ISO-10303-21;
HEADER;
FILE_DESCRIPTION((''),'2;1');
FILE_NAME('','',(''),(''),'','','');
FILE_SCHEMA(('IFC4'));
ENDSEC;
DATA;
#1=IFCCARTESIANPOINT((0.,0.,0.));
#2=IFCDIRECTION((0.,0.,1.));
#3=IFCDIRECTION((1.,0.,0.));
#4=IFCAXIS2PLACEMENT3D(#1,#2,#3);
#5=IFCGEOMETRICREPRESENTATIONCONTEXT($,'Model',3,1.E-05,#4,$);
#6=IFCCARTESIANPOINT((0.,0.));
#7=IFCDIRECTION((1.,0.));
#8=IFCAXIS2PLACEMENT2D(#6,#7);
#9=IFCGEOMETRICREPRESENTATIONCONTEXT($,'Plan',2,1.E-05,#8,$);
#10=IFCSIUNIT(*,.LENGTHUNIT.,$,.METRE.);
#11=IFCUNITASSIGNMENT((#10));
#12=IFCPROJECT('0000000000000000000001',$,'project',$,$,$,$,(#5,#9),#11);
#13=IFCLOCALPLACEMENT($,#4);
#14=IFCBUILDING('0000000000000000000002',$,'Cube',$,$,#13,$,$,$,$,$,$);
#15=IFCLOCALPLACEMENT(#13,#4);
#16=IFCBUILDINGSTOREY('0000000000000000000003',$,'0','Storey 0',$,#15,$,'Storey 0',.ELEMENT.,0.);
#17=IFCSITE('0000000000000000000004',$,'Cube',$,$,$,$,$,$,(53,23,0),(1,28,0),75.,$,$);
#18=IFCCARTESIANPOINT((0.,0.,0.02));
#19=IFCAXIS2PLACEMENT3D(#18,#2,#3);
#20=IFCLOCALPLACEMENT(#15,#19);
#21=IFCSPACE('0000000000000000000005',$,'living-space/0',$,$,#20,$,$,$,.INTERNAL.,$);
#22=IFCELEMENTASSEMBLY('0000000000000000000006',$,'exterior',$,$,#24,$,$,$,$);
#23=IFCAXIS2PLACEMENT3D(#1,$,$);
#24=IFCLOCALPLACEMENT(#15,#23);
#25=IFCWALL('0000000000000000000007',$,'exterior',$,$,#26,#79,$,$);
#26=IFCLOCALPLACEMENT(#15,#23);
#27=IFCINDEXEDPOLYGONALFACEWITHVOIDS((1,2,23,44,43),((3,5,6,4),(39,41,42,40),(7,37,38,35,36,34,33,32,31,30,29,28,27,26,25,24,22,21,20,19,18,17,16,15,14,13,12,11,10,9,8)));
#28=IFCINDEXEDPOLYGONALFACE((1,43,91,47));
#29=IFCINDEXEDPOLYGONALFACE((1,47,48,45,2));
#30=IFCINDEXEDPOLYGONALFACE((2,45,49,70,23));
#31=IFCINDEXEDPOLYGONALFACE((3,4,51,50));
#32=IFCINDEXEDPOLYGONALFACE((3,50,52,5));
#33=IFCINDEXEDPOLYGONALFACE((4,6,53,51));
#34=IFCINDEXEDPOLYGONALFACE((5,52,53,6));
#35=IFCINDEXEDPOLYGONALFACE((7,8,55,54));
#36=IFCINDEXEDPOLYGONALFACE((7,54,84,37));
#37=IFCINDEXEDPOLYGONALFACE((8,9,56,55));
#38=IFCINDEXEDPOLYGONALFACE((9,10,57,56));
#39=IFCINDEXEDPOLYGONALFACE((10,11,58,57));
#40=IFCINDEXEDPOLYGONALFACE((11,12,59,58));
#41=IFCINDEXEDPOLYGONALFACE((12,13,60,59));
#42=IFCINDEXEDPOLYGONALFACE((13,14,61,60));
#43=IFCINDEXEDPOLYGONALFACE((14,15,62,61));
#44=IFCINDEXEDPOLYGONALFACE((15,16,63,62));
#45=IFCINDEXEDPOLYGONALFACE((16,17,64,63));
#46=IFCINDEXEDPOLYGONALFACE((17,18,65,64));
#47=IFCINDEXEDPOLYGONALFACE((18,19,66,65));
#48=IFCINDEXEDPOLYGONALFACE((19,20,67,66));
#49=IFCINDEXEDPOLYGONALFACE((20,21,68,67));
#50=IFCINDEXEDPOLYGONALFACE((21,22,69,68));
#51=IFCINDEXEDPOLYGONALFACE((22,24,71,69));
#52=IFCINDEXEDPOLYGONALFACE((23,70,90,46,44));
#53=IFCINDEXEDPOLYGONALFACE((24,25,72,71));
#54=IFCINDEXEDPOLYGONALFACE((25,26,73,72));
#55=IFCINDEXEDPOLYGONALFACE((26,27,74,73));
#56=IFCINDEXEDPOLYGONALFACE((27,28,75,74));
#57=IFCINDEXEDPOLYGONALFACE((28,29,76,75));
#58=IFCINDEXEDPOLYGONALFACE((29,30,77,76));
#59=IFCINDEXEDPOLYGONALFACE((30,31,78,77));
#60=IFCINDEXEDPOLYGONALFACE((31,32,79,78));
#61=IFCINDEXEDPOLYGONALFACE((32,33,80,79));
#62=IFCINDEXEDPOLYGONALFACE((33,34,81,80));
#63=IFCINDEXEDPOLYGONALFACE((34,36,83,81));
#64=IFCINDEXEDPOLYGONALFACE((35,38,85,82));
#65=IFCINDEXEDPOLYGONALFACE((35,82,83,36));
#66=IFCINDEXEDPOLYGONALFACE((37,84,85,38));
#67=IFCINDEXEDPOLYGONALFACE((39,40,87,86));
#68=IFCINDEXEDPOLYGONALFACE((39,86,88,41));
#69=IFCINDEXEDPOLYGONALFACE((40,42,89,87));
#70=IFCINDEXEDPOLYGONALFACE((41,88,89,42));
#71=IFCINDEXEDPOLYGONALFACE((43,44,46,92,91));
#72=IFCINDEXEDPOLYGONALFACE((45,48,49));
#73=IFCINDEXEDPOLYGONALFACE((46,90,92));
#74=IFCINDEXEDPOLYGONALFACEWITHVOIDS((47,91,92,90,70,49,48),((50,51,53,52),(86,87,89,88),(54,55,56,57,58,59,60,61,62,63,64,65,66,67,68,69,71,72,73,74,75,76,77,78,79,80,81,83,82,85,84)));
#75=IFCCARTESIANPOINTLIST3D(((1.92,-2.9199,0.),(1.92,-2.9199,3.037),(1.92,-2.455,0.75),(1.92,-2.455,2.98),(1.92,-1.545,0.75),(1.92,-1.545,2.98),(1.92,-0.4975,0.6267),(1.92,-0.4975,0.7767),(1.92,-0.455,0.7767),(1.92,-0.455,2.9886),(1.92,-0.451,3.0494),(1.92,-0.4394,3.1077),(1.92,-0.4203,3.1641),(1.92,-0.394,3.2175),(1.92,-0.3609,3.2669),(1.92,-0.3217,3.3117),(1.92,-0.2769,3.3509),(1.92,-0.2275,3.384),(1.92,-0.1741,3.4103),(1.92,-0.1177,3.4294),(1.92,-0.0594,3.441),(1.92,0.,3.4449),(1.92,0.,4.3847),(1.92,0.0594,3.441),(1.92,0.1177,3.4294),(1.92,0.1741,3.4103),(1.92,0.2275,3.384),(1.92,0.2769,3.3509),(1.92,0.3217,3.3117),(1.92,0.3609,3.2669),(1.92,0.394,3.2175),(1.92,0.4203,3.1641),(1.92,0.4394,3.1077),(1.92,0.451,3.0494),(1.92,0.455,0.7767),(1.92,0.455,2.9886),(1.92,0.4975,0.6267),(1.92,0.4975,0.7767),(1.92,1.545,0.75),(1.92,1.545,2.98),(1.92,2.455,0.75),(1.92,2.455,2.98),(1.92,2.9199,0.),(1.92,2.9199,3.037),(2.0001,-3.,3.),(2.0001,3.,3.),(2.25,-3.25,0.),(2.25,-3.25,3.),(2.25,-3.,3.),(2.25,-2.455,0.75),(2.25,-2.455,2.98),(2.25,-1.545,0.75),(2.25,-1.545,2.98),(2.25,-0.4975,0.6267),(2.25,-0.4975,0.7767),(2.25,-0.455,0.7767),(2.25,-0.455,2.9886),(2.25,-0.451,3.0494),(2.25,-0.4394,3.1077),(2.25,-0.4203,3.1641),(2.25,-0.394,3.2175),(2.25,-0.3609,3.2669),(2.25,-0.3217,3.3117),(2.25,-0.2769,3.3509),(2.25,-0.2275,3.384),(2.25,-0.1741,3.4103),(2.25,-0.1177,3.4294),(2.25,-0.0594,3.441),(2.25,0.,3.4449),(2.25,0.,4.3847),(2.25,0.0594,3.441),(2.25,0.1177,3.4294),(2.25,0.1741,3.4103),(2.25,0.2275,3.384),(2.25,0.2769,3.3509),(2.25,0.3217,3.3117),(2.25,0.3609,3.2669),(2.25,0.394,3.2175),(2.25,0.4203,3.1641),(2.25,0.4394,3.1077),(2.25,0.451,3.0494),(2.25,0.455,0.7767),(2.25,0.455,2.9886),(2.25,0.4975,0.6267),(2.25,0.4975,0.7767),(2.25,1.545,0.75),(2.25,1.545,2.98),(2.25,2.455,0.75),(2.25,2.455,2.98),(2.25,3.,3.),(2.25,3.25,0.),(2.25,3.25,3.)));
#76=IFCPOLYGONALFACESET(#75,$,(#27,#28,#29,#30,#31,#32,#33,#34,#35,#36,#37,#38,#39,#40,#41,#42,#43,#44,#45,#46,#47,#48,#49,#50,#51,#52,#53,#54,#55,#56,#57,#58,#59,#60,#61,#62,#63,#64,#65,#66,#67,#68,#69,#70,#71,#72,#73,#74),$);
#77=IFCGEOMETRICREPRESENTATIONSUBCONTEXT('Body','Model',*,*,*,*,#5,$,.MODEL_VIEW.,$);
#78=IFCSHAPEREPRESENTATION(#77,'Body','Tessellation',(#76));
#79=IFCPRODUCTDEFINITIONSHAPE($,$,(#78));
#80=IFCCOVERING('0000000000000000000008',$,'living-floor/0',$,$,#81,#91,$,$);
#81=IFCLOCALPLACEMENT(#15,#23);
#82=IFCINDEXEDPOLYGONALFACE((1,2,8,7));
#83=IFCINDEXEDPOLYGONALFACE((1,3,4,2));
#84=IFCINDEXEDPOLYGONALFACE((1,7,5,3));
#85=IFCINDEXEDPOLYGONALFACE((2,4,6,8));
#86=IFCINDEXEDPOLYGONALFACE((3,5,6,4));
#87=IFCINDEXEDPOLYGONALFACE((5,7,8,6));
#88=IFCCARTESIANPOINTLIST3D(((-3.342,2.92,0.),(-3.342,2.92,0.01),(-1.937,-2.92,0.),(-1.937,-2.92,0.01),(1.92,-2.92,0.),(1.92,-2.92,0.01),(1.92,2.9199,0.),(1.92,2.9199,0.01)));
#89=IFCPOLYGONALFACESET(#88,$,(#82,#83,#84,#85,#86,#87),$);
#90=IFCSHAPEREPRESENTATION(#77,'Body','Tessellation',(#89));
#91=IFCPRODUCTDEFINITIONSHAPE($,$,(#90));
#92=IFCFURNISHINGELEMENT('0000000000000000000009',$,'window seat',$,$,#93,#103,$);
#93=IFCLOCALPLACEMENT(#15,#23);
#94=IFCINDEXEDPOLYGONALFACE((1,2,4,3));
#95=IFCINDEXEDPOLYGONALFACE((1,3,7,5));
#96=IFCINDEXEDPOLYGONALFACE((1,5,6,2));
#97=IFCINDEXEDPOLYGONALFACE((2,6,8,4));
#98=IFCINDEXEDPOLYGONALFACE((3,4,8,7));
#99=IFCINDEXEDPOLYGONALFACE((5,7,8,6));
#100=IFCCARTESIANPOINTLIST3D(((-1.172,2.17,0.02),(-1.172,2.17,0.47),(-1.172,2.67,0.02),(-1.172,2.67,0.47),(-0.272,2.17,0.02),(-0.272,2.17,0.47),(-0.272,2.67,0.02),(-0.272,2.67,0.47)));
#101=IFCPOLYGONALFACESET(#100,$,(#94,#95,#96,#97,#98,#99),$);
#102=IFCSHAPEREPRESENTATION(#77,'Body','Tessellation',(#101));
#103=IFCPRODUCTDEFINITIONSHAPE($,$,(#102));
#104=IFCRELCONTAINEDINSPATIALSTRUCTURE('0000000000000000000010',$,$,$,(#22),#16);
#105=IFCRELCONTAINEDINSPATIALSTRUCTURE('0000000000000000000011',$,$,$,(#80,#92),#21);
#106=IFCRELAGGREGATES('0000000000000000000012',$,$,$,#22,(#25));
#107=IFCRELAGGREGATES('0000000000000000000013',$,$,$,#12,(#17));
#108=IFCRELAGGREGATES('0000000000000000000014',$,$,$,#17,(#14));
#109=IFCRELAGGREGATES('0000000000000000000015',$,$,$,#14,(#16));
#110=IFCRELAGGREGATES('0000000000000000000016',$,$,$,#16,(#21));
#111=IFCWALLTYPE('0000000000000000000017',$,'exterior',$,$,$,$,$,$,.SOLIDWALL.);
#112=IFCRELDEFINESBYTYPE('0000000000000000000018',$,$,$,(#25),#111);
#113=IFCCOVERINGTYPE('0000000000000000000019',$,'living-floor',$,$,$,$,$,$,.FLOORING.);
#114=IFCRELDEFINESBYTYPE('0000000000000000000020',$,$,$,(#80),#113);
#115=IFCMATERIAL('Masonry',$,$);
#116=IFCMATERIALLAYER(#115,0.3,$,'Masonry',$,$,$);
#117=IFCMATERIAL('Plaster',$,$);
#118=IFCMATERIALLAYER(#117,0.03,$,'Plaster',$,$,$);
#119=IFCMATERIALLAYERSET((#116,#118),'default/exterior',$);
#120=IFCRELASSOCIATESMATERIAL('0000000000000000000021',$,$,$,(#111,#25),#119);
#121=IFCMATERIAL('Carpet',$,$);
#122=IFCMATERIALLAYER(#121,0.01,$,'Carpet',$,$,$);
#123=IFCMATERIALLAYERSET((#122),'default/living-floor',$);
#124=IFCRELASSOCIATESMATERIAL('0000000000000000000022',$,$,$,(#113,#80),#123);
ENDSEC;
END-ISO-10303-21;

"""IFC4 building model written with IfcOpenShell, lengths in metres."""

from ifc_helpers import new_model, si_unit, frame, origin, origin_with_axes, origin_2d_with_axis, place, context, subcontext, project, spatial, polyline, indexed_curve, outline, extrude, clip, bounded_halfspace, material, layer, layer_set, layer_usage, type_object, element, aggregate, save


model = new_model("IFC4")

# Units and contexts
model_context = context("Model", 3, precision=1e-05, world=origin_with_axes())
plan_context = context("Plan", 2, precision=1e-05, world=origin_2d_with_axis())
body_context = subcontext(model_context, "Body", "Model", "MODEL_VIEW")
ifc_project = project(units=[si_unit("LENGTHUNIT", "METRE")], contexts=[model_context, plan_context])

# Site, building, storey
site = spatial("IfcSite", under=ifc_project, Name="Cube", RefLatitude=(53, 23, 0), RefLongitude=(1, 28, 0), RefElevation=75.0)
building_placement = place(None, origin_with_axes())
building = spatial("IfcBuilding", under=site, at=building_placement, Name="Cube")
storey_placement = place(building_placement, origin_with_axes())
storey = spatial("IfcBuildingStorey", under=building, at=storey_placement, Name="0", Description="Storey 0", LongName="Storey 0", CompositionType="ELEMENT", Elevation=0.0)

# Element assembly, wall, openings
ifc_material_1 = material(Name="Masonry")
ifc_layer_1 = layer(ifc_material_1, 0.3, Name="Masonry")
ifc_material_2 = material(Name="Plaster")
ifc_layer_2 = layer(ifc_material_2, 0.03, Name="Plaster")
ifc_layer_set_1 = layer_set([ifc_layer_1, ifc_layer_2], Name="default/exterior")
wall_type = type_object("IfcWallType", Name="exterior", PredefinedType="SOLIDWALL", material=ifc_layer_set_1)
assembly_1_placement = place(storey_placement, frame((2.0, -3.0, 0.0), z_axis=(0.0, 0.0, 1.0), x_axis=(0.0, 1.0, 0.0)))
assembly_1 = element("IfcElementAssembly", 1, at=assembly_1_placement, inside=storey, Name="exterior")
ifc_layer_usage_1 = layer_usage(ifc_layer_set_1, "AXIS2", "POSITIVE", -0.25)
wall_1_placement = place(assembly_1_placement, origin_with_axes())
wall_1 = element("IfcWall", 2, at=wall_1_placement, type_object=wall_type, material=ifc_layer_usage_1, Name="exterior", context=body_context, shape_type="Clipping", body=[
    clip(clip(clip(clip(extrude(outline(polyline([(0.0801, 0.08), (-0.25, -0.25), (6.25, -0.25), (5.9199, 0.08), (0.0801, 0.08)])), origin(), (0.0, 0.0, 1.0), 4.385), bounded_halfspace(frame((6.0, 0.0, 3.0), z_axis=(0.419069, 0.0, 0.907954), x_axis=(0.0, -1.0, 0.0)), False, origin(), polyline([(6.0, -1.0), (3.0, -1.0), (3.0, 1.0), (6.0, 1.0), (6.0, -1.0)]))), bounded_halfspace(frame((6.0, 0.0, 3.0), z_axis=(0.0, 0.0, 1.0), x_axis=(0.0, 1.0, 0.0)), False, origin(), polyline([(6.0, 1.0), (7.0, 1.0), (7.0, -1.0), (6.0, -1.0), (6.0, 1.0)]))), bounded_halfspace(frame((3.0, 0.0, 4.3847), z_axis=(-0.419069, 0.0, 0.907954), x_axis=(0.0, -1.0, 0.0)), False, origin(), polyline([(3.0, -1.0), (0.0, -1.0), (0.0, 1.0), (3.0, 1.0), (3.0, -1.0)]))), bounded_halfspace(frame((0.0, 0.0, 3.0), z_axis=(0.0, 0.0, 1.0), x_axis=(0.0, -1.0, 0.0)), False, origin(), polyline([(0.0, -1.0), (-1.0, -1.0), (-1.0, 1.0), (0.0, 1.0), (0.0, -1.0)]))),
])
opening_1_placement = place(wall_1_placement, frame((0.545, -0.25, 0.75), z_axis=(0.0, 0.0, 1.0), x_axis=(1.0, 0.0, 0.0)))
element("IfcOpeningElement", 3, at=opening_1_placement, cuts=wall_1, PredefinedType="OPENING", context=body_context, shape_type="SweptSolid", body=[
    extrude(outline(polyline([(0.0, -0.02), (0.91, -0.02), (0.91, 0.35), (0.0, 0.35), (0.0, -0.02)])), origin(), (0.0, 0.0, 1.0), 2.23),
])
opening_2_placement = place(wall_1_placement, frame((2.545, -0.25, 0.75), z_axis=(0.0, 0.0, 1.0), x_axis=(1.0, 0.0, 0.0)))
element("IfcOpeningElement", 4, at=opening_2_placement, cuts=wall_1, PredefinedType="OPENING", context=body_context, shape_type="SweptSolid", body=[
    extrude(outline(polyline([(0.1333, 2.5617), (0.1781, 2.6009), (0.2275, 2.634), (0.2809, 2.6603), (0.3373, 2.6794), (0.3956, 2.691), (0.455, 2.6949), (0.5144, 2.691), (0.5727, 2.6794), (0.6291, 2.6603), (0.6825, 2.634), (0.7319, 2.6009), (0.7767, 2.5617), (0.8159, 2.5169), (0.849, 2.4675), (0.8753, 2.4141), (0.8944, 2.3577), (0.906, 2.2994), (0.91, 2.2386), (0.91, 2.2069), (0.91, 0.0267), (0.9525, 0.0267), (0.9525, -0.1233), (-0.0425, -0.1233), (-0.0425, 0.0267), (0.0, 0.0267), (0.0, 2.2069), (0.0, 2.2386), (0.004, 2.2994), (0.0156, 2.3577), (0.0347, 2.4141), (0.061, 2.4675), (0.0941, 2.5169), (0.1333, 2.5617)])), frame((0.0, -0.02, 0.0), z_axis=(0.0, -1.0, 0.0), x_axis=(1.0, 0.0, 0.0)), (0.0, 0.0, -1.0), 0.37),
])
opening_3_placement = place(wall_1_placement, frame((4.545, -0.25, 0.75), z_axis=(0.0, 0.0, 1.0), x_axis=(1.0, 0.0, 0.0)))
element("IfcOpeningElement", 5, at=opening_3_placement, cuts=wall_1, PredefinedType="OPENING", context=body_context, shape_type="SweptSolid", body=[
    extrude(outline(polyline([(0.0, -0.02), (0.91, -0.02), (0.91, 0.35), (0.0, 0.35), (0.0, -0.02)])), origin(), (0.0, 0.0, 1.0), 2.23),
])
aggregate(assembly_1, [wall_1])

# Shared definitions
space_placement = place(storey_placement, frame((0.0, 0.0, 0.02), z_axis=(0.0, 0.0, 1.0), x_axis=(1.0, 0.0, 0.0)))
space = spatial("IfcSpace", under=storey, at=space_placement, Name="living-space/0", PredefinedType="INTERNAL")

# Covering
ifc_material_3 = material(Name="Carpet")
ifc_layer_3 = layer(ifc_material_3, 0.01, Name="Carpet")
ifc_layer_set_2 = layer_set([ifc_layer_3], Name="default/living-floor")
ifc_layer_usage_2 = layer_usage(ifc_layer_set_2, "AXIS3", "POSITIVE", 0.0)
covering_type = type_object("IfcCoveringType", Name="living-floor", PredefinedType="FLOORING", material=ifc_layer_set_2)
covering_placement = place(space_placement, frame((0.0, 0.0, -0.02), z_axis=(0.0, 0.0, 1.0), x_axis=(1.0, 0.0, 0.0)))
element("IfcCovering", 6, at=covering_placement, inside=space, type_object=covering_type, material=ifc_layer_usage_2, Name="living-floor/0", context=body_context, shape_type="SweptSolid", body=[
    extrude(outline(polyline([(1.92, 2.9199), (-3.342, 2.92), (-1.937, -2.92), (1.92, -2.92), (1.92, 2.9199)])), origin_with_axes(), (0.0, 0.0, 1.0), 0.01),
])

# Furnishing element
furnishing_placement = place(space_placement, frame((-1.172, 2.17, 0.0), z_axis=(0.0, 0.0, 1.0), x_axis=(1.0, 0.0, 0.0)))
element("IfcFurnishingElement", 7, at=furnishing_placement, inside=space, Name="window seat", context=body_context, shape_type="SweptSolid", body=[
    extrude(outline(indexed_curve([(0.0, 0.0), (0.9, 0.0), (0.9, 0.5), (0.0, 0.5)])), None, (0.0, 0.0, 1.0), 0.45),
])

save(model, "model.ifc")
